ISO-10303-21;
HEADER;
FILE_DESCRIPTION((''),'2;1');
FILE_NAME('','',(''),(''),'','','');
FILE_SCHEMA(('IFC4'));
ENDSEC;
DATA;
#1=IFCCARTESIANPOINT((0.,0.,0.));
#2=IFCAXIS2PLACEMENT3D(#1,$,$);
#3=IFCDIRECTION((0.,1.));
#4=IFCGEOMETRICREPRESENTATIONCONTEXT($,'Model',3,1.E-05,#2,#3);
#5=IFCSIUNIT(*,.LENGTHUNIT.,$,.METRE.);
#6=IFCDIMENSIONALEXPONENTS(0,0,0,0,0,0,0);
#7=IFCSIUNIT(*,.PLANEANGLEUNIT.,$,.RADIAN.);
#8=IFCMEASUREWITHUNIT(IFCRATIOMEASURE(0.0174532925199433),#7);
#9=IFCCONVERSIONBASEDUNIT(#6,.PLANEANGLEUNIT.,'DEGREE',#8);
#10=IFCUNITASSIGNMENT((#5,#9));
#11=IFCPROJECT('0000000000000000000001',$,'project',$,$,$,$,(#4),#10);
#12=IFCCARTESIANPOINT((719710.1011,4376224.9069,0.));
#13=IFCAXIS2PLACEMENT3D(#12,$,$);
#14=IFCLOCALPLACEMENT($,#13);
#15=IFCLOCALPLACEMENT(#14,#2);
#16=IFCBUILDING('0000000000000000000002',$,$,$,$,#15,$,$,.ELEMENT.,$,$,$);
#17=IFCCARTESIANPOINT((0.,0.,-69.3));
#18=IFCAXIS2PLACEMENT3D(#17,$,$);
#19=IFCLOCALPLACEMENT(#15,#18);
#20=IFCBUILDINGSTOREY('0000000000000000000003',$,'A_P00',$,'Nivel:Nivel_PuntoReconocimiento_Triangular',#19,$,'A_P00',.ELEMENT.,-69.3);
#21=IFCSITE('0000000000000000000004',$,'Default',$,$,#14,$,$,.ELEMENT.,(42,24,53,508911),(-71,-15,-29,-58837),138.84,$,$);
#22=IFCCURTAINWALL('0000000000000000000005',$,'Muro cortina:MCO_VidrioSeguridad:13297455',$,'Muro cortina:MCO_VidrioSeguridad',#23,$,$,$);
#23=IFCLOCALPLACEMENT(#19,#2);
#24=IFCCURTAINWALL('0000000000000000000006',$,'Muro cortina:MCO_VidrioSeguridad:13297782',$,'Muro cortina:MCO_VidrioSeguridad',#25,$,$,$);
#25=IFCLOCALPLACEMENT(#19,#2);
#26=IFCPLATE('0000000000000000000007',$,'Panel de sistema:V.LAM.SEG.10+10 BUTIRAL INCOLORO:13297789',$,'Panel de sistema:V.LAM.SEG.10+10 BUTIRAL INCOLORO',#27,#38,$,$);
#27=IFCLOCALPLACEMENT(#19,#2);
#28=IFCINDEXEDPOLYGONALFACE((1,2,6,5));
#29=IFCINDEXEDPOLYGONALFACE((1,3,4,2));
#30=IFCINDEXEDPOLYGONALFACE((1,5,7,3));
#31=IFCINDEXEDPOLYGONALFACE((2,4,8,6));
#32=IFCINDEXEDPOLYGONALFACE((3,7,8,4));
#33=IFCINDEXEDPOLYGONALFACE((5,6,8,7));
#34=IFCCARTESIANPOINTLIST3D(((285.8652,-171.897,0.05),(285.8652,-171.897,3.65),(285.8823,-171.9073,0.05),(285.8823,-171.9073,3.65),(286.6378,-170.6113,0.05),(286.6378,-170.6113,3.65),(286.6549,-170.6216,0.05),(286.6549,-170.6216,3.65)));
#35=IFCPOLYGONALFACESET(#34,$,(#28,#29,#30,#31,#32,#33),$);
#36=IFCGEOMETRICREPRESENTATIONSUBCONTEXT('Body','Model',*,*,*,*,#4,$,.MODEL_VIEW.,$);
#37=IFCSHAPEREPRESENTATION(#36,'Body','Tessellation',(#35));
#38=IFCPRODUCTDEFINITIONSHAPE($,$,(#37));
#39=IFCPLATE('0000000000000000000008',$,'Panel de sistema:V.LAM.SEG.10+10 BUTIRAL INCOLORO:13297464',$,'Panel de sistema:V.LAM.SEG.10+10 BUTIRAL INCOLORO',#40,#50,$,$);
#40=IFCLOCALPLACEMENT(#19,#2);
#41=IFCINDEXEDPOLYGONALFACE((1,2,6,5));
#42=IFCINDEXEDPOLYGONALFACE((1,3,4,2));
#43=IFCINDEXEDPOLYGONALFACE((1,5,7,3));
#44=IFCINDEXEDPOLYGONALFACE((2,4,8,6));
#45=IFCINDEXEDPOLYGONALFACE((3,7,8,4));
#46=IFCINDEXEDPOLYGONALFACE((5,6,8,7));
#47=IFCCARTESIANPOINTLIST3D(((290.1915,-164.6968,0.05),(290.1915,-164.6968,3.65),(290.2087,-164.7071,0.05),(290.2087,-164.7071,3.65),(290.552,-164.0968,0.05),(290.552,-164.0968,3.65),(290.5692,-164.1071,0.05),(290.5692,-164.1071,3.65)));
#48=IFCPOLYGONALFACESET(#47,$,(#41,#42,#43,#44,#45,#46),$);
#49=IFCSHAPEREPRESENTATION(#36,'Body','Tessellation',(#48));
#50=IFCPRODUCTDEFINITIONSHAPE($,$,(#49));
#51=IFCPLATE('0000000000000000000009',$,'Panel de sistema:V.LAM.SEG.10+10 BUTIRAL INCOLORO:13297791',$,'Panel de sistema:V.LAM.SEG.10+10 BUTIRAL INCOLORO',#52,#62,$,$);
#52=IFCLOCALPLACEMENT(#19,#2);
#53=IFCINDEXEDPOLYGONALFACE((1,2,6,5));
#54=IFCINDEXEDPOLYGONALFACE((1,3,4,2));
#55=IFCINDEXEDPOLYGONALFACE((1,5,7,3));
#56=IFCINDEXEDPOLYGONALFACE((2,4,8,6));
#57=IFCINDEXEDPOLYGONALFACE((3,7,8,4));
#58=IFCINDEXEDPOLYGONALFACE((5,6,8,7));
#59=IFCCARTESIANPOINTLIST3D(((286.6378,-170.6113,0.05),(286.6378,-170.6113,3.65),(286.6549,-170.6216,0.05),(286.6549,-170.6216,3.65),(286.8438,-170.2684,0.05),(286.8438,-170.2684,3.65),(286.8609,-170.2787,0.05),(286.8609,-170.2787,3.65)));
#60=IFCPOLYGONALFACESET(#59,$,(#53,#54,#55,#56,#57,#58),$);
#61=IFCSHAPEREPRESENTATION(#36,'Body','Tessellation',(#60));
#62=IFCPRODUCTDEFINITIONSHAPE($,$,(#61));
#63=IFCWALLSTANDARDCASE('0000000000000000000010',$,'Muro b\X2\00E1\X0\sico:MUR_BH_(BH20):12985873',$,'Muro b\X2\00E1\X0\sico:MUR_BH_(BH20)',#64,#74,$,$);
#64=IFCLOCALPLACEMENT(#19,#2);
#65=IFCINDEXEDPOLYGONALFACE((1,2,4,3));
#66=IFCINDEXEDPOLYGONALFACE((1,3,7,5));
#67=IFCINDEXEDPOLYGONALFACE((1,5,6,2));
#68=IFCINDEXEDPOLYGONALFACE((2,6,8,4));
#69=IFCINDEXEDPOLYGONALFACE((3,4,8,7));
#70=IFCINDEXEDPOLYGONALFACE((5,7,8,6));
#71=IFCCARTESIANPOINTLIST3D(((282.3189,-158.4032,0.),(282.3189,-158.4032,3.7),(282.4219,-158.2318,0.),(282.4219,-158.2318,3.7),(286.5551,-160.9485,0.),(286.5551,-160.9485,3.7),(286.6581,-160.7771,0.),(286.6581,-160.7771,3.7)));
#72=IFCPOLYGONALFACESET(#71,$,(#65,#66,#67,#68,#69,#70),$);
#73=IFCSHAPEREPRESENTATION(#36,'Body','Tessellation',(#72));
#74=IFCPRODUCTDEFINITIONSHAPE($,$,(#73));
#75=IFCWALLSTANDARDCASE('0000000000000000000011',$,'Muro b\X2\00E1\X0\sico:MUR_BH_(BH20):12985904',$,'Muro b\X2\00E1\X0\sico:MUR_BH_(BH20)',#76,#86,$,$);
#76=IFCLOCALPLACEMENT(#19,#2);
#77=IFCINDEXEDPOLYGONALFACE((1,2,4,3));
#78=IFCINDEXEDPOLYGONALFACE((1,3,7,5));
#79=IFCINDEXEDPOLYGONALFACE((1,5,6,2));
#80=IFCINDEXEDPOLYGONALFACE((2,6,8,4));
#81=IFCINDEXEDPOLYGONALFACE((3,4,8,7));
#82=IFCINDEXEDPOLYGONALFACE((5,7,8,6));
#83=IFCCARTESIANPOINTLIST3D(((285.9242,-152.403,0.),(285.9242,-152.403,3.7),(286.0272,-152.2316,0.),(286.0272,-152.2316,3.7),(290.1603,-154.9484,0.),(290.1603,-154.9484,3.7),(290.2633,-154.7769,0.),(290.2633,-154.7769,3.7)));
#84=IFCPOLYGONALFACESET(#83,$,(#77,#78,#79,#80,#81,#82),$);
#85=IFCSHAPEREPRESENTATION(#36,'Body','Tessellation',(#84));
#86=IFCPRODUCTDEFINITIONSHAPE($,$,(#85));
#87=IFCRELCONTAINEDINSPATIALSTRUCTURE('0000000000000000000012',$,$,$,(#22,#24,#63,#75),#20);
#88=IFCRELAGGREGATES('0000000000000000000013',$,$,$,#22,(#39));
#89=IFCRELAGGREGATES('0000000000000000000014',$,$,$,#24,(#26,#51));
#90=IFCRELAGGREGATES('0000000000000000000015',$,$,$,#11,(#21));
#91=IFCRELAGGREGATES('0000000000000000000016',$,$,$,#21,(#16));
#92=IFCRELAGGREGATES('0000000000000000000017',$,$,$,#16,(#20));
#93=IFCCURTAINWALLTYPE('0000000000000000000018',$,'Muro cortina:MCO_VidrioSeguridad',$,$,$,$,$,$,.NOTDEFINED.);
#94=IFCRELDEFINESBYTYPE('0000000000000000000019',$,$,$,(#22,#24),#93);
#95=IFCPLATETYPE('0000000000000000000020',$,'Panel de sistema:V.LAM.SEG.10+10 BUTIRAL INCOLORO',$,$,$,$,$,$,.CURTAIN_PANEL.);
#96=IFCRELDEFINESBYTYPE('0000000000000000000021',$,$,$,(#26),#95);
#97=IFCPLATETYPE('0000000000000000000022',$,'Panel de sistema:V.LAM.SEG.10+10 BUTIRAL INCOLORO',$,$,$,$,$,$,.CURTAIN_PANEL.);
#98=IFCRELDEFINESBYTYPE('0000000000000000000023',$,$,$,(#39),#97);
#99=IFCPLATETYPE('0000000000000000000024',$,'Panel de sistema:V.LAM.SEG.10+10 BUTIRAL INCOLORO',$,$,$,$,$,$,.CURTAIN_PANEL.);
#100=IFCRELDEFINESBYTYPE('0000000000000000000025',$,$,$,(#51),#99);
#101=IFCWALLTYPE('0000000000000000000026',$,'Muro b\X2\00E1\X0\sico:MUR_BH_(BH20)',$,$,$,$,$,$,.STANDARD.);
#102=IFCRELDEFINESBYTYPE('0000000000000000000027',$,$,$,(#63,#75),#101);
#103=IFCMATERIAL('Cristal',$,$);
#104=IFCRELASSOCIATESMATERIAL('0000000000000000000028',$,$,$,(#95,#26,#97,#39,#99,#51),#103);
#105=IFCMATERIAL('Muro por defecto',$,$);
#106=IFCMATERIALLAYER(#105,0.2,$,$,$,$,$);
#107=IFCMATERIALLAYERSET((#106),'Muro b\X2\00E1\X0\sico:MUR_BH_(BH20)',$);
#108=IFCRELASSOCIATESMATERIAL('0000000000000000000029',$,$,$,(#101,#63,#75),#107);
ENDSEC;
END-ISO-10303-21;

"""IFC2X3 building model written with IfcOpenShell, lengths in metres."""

from ifc_helpers import new_model, entity, si_unit, converted_unit, direction, frame, frame_2d, origin, origin_2d_with_axis, place, context, subcontext, project, spatial, rectangle, extrude, source, transform, mapped, material, layer, layer_set, layer_usage, type_object, type_shapes, element, aggregate, save


model = new_model("IFC2X3")

# Units and contexts
model_context = context("Model", 3, precision=1e-05, world=origin(), true_north=direction((0.0, 1.0)))
body_context = subcontext(model_context, "Body", "Model", "MODEL_VIEW")
ifc_project = project(units=[si_unit("LENGTHUNIT", "METRE"), converted_unit("PLANEANGLEUNIT", "DEGREE", entity("IfcRatioMeasure", 0.0174532925199433), si_unit("PLANEANGLEUNIT", "RADIAN"), dimensions=[0, 0, 0, 0, 0, 0, 0])], contexts=[model_context])

# Site, building, storey
site_placement = place(None, frame((719710.1011, 4376224.9069, 0.0)))
site = spatial("IfcSite", under=ifc_project, at=site_placement, Name="Default", CompositionType="ELEMENT", RefLatitude=(42, 24, 53, 508911), RefLongitude=(-71, -15, -29, -58837), RefElevation=138.84)
building_placement = place(site_placement, origin())
building = spatial("IfcBuilding", under=site, at=building_placement, CompositionType="ELEMENT")
storey_placement = place(building_placement, frame((0.0, 0.0, -69.3)))
storey = spatial("IfcBuildingStorey", under=building, at=storey_placement, Name="A_P00", ObjectType="Nivel:Nivel_PuntoReconocimiento_Triangular", LongName="A_P00", CompositionType="ELEMENT", Elevation=-69.3)

# Shared definitions
curtain_wall_type = type_object("IfcCurtainWallType", Name="Muro cortina:MCO_VidrioSeguridad", PredefinedType="NOTDEFINED")
ifc_material_1 = material(Name="Cristal")
plate_type_1 = type_object("IfcPlateType", Name="Panel de sistema:V.LAM.SEG.10+10 BUTIRAL INCOLORO", PredefinedType="CURTAIN_PANEL", material=ifc_material_1)
shared_shape_1 = source(origin(), body_context, "Body", "SweptSolid", [
    extrude(rectangle(XDim=0.02, YDim=1.5, at=origin_2d_with_axis()), frame((0.0, 0.0, 0.0), z_axis=(0.0, 0.0, 1.0), x_axis=(0.0, 1.0, 0.0)), (0.0, 0.0, 1.0), 3.6),
])
type_shapes(plate_type_1, [shared_shape_1])

# Curtain walls, plate
curtain_wall_1_placement = place(storey_placement, frame((0.0, 0.0, 69.3)))
curtain_wall_1 = element("IfcCurtainWall", 1, at=curtain_wall_1_placement, inside=storey, type_object=curtain_wall_type, Name="Muro cortina:MCO_VidrioSeguridad:13297455", ObjectType="Muro cortina:MCO_VidrioSeguridad")
curtain_wall_2_placement = place(storey_placement, frame((0.0, 0.0, 69.3)))
curtain_wall_2 = element("IfcCurtainWall", 2, at=curtain_wall_2_placement, inside=storey, type_object=curtain_wall_type, Name="Muro cortina:MCO_VidrioSeguridad:13297782", ObjectType="Muro cortina:MCO_VidrioSeguridad")
plate_1_placement = place(curtain_wall_2_placement, frame((286.2601, -171.2593, -69.25), z_axis=(0.0, 0.0, 1.0), x_axis=(0.515038, 0.857167, 0.0)))
plate_1 = element("IfcPlate", 3, at=plate_1_placement, type_object=plate_type_1, material=ifc_material_1, Name="Panel de sistema:V.LAM.SEG.10+10 BUTIRAL INCOLORO:13297789", ObjectType="Panel de sistema:V.LAM.SEG.10+10 BUTIRAL INCOLORO", context=body_context, shape_type="MappedRepresentation", body=[
    mapped(shared_shape_1, transform((0.0, 0.0, 0.0), scale=1.0)),
])

# Plates
plate_type_2 = type_object("IfcPlateType", Name="Panel de sistema:V.LAM.SEG.10+10 BUTIRAL INCOLORO", PredefinedType="CURTAIN_PANEL", material=ifc_material_1)
shared_shape_2 = source(origin(), body_context, "Body", "SweptSolid", [
    extrude(rectangle(XDim=0.02, YDim=0.7, at=origin_2d_with_axis()), frame((0.0, 0.0, 0.0), z_axis=(0.0, 0.0, 1.0), x_axis=(0.0, 1.0, 0.0)), (0.0, 0.0, 1.0), 3.6),
])
type_shapes(plate_type_2, [shared_shape_2])
plate_2_placement = place(curtain_wall_1_placement, frame((290.3804, -164.402, -69.25), z_axis=(0.0, 0.0, 1.0), x_axis=(0.515038, 0.857167, 0.0)))
plate_2 = element("IfcPlate", 4, at=plate_2_placement, type_object=plate_type_2, material=ifc_material_1, Name="Panel de sistema:V.LAM.SEG.10+10 BUTIRAL INCOLORO:13297464", ObjectType="Panel de sistema:V.LAM.SEG.10+10 BUTIRAL INCOLORO", context=body_context, shape_type="MappedRepresentation", body=[
    mapped(shared_shape_2, transform((0.0, 0.0, 0.0), scale=1.0)),
])
aggregate(curtain_wall_1, [plate_2])
plate_type_3 = type_object("IfcPlateType", Name="Panel de sistema:V.LAM.SEG.10+10 BUTIRAL INCOLORO", PredefinedType="CURTAIN_PANEL", material=ifc_material_1)
shared_shape_3 = source(origin(), body_context, "Body", "SweptSolid", [
    extrude(rectangle(XDim=0.02, YDim=0.4, at=origin_2d_with_axis()), frame((0.0, 0.0, 0.0), z_axis=(0.0, 0.0, 1.0), x_axis=(0.0, 1.0, 0.0)), (0.0, 0.0, 1.0), 3.6),
])
type_shapes(plate_type_3, [shared_shape_3])
plate_3_placement = place(curtain_wall_2_placement, frame((286.7493, -170.445, -69.25), z_axis=(0.0, 0.0, 1.0), x_axis=(0.515038, 0.857167, 0.0)))
plate_3 = element("IfcPlate", 5, at=plate_3_placement, type_object=plate_type_3, material=ifc_material_1, Name="Panel de sistema:V.LAM.SEG.10+10 BUTIRAL INCOLORO:13297791", ObjectType="Panel de sistema:V.LAM.SEG.10+10 BUTIRAL INCOLORO", context=body_context, shape_type="MappedRepresentation", body=[
    mapped(shared_shape_3, transform((0.0, 0.0, 0.0), scale=1.0)),
])
aggregate(curtain_wall_2, [plate_1, plate_3])

# Walls
ifc_material_2 = material(Name="Muro por defecto")
ifc_layer = layer(ifc_material_2, 0.2)
ifc_layer_set = layer_set([ifc_layer], Name="Muro básico:MUR_BH_(BH20)")
ifc_layer_usage_1 = layer_usage(ifc_layer_set, "AXIS2", "NEGATIVE", 0.1)
wall_type = type_object("IfcWallType", Name="Muro básico:MUR_BH_(BH20)", PredefinedType="STANDARD", material=ifc_layer_set)
wall_1_placement = place(storey_placement, frame((286.6066, -160.8628, 0.0), z_axis=(0.0, 0.0, 1.0), x_axis=(-0.857167, 0.515038, 0.0)))
element("IfcWallStandardCase", 6, at=wall_1_placement, inside=storey, type_object=wall_type, material=ifc_layer_usage_1, Name="Muro básico:MUR_BH_(BH20):12985873", ObjectType="Muro básico:MUR_BH_(BH20)", context=body_context, shape_type="SweptSolid", body=[
    extrude(rectangle(XDim=4.942, YDim=0.2, at=frame_2d((2.471, 0.0), x_axis=(-1.0, 0.0))), origin(), (0.0, 0.0, 1.0), 3.7),
])
ifc_layer_usage_2 = layer_usage(ifc_layer_set, "AXIS2", "NEGATIVE", 0.1)
wall_2_placement = place(storey_placement, frame((290.2118, -154.8626, 0.0), z_axis=(0.0, 0.0, 1.0), x_axis=(-0.857167, 0.515038, 0.0)))
element("IfcWallStandardCase", 7, at=wall_2_placement, inside=storey, type_object=wall_type, material=ifc_layer_usage_2, Name="Muro básico:MUR_BH_(BH20):12985904", ObjectType="Muro básico:MUR_BH_(BH20)", context=body_context, shape_type="SweptSolid", body=[
    extrude(rectangle(XDim=4.942, YDim=0.2, at=frame_2d((2.471, 0.0), x_axis=(-1.0, 0.0))), origin(), (0.0, 0.0, 1.0), 3.7),
])

save(model, "model.ifc")
